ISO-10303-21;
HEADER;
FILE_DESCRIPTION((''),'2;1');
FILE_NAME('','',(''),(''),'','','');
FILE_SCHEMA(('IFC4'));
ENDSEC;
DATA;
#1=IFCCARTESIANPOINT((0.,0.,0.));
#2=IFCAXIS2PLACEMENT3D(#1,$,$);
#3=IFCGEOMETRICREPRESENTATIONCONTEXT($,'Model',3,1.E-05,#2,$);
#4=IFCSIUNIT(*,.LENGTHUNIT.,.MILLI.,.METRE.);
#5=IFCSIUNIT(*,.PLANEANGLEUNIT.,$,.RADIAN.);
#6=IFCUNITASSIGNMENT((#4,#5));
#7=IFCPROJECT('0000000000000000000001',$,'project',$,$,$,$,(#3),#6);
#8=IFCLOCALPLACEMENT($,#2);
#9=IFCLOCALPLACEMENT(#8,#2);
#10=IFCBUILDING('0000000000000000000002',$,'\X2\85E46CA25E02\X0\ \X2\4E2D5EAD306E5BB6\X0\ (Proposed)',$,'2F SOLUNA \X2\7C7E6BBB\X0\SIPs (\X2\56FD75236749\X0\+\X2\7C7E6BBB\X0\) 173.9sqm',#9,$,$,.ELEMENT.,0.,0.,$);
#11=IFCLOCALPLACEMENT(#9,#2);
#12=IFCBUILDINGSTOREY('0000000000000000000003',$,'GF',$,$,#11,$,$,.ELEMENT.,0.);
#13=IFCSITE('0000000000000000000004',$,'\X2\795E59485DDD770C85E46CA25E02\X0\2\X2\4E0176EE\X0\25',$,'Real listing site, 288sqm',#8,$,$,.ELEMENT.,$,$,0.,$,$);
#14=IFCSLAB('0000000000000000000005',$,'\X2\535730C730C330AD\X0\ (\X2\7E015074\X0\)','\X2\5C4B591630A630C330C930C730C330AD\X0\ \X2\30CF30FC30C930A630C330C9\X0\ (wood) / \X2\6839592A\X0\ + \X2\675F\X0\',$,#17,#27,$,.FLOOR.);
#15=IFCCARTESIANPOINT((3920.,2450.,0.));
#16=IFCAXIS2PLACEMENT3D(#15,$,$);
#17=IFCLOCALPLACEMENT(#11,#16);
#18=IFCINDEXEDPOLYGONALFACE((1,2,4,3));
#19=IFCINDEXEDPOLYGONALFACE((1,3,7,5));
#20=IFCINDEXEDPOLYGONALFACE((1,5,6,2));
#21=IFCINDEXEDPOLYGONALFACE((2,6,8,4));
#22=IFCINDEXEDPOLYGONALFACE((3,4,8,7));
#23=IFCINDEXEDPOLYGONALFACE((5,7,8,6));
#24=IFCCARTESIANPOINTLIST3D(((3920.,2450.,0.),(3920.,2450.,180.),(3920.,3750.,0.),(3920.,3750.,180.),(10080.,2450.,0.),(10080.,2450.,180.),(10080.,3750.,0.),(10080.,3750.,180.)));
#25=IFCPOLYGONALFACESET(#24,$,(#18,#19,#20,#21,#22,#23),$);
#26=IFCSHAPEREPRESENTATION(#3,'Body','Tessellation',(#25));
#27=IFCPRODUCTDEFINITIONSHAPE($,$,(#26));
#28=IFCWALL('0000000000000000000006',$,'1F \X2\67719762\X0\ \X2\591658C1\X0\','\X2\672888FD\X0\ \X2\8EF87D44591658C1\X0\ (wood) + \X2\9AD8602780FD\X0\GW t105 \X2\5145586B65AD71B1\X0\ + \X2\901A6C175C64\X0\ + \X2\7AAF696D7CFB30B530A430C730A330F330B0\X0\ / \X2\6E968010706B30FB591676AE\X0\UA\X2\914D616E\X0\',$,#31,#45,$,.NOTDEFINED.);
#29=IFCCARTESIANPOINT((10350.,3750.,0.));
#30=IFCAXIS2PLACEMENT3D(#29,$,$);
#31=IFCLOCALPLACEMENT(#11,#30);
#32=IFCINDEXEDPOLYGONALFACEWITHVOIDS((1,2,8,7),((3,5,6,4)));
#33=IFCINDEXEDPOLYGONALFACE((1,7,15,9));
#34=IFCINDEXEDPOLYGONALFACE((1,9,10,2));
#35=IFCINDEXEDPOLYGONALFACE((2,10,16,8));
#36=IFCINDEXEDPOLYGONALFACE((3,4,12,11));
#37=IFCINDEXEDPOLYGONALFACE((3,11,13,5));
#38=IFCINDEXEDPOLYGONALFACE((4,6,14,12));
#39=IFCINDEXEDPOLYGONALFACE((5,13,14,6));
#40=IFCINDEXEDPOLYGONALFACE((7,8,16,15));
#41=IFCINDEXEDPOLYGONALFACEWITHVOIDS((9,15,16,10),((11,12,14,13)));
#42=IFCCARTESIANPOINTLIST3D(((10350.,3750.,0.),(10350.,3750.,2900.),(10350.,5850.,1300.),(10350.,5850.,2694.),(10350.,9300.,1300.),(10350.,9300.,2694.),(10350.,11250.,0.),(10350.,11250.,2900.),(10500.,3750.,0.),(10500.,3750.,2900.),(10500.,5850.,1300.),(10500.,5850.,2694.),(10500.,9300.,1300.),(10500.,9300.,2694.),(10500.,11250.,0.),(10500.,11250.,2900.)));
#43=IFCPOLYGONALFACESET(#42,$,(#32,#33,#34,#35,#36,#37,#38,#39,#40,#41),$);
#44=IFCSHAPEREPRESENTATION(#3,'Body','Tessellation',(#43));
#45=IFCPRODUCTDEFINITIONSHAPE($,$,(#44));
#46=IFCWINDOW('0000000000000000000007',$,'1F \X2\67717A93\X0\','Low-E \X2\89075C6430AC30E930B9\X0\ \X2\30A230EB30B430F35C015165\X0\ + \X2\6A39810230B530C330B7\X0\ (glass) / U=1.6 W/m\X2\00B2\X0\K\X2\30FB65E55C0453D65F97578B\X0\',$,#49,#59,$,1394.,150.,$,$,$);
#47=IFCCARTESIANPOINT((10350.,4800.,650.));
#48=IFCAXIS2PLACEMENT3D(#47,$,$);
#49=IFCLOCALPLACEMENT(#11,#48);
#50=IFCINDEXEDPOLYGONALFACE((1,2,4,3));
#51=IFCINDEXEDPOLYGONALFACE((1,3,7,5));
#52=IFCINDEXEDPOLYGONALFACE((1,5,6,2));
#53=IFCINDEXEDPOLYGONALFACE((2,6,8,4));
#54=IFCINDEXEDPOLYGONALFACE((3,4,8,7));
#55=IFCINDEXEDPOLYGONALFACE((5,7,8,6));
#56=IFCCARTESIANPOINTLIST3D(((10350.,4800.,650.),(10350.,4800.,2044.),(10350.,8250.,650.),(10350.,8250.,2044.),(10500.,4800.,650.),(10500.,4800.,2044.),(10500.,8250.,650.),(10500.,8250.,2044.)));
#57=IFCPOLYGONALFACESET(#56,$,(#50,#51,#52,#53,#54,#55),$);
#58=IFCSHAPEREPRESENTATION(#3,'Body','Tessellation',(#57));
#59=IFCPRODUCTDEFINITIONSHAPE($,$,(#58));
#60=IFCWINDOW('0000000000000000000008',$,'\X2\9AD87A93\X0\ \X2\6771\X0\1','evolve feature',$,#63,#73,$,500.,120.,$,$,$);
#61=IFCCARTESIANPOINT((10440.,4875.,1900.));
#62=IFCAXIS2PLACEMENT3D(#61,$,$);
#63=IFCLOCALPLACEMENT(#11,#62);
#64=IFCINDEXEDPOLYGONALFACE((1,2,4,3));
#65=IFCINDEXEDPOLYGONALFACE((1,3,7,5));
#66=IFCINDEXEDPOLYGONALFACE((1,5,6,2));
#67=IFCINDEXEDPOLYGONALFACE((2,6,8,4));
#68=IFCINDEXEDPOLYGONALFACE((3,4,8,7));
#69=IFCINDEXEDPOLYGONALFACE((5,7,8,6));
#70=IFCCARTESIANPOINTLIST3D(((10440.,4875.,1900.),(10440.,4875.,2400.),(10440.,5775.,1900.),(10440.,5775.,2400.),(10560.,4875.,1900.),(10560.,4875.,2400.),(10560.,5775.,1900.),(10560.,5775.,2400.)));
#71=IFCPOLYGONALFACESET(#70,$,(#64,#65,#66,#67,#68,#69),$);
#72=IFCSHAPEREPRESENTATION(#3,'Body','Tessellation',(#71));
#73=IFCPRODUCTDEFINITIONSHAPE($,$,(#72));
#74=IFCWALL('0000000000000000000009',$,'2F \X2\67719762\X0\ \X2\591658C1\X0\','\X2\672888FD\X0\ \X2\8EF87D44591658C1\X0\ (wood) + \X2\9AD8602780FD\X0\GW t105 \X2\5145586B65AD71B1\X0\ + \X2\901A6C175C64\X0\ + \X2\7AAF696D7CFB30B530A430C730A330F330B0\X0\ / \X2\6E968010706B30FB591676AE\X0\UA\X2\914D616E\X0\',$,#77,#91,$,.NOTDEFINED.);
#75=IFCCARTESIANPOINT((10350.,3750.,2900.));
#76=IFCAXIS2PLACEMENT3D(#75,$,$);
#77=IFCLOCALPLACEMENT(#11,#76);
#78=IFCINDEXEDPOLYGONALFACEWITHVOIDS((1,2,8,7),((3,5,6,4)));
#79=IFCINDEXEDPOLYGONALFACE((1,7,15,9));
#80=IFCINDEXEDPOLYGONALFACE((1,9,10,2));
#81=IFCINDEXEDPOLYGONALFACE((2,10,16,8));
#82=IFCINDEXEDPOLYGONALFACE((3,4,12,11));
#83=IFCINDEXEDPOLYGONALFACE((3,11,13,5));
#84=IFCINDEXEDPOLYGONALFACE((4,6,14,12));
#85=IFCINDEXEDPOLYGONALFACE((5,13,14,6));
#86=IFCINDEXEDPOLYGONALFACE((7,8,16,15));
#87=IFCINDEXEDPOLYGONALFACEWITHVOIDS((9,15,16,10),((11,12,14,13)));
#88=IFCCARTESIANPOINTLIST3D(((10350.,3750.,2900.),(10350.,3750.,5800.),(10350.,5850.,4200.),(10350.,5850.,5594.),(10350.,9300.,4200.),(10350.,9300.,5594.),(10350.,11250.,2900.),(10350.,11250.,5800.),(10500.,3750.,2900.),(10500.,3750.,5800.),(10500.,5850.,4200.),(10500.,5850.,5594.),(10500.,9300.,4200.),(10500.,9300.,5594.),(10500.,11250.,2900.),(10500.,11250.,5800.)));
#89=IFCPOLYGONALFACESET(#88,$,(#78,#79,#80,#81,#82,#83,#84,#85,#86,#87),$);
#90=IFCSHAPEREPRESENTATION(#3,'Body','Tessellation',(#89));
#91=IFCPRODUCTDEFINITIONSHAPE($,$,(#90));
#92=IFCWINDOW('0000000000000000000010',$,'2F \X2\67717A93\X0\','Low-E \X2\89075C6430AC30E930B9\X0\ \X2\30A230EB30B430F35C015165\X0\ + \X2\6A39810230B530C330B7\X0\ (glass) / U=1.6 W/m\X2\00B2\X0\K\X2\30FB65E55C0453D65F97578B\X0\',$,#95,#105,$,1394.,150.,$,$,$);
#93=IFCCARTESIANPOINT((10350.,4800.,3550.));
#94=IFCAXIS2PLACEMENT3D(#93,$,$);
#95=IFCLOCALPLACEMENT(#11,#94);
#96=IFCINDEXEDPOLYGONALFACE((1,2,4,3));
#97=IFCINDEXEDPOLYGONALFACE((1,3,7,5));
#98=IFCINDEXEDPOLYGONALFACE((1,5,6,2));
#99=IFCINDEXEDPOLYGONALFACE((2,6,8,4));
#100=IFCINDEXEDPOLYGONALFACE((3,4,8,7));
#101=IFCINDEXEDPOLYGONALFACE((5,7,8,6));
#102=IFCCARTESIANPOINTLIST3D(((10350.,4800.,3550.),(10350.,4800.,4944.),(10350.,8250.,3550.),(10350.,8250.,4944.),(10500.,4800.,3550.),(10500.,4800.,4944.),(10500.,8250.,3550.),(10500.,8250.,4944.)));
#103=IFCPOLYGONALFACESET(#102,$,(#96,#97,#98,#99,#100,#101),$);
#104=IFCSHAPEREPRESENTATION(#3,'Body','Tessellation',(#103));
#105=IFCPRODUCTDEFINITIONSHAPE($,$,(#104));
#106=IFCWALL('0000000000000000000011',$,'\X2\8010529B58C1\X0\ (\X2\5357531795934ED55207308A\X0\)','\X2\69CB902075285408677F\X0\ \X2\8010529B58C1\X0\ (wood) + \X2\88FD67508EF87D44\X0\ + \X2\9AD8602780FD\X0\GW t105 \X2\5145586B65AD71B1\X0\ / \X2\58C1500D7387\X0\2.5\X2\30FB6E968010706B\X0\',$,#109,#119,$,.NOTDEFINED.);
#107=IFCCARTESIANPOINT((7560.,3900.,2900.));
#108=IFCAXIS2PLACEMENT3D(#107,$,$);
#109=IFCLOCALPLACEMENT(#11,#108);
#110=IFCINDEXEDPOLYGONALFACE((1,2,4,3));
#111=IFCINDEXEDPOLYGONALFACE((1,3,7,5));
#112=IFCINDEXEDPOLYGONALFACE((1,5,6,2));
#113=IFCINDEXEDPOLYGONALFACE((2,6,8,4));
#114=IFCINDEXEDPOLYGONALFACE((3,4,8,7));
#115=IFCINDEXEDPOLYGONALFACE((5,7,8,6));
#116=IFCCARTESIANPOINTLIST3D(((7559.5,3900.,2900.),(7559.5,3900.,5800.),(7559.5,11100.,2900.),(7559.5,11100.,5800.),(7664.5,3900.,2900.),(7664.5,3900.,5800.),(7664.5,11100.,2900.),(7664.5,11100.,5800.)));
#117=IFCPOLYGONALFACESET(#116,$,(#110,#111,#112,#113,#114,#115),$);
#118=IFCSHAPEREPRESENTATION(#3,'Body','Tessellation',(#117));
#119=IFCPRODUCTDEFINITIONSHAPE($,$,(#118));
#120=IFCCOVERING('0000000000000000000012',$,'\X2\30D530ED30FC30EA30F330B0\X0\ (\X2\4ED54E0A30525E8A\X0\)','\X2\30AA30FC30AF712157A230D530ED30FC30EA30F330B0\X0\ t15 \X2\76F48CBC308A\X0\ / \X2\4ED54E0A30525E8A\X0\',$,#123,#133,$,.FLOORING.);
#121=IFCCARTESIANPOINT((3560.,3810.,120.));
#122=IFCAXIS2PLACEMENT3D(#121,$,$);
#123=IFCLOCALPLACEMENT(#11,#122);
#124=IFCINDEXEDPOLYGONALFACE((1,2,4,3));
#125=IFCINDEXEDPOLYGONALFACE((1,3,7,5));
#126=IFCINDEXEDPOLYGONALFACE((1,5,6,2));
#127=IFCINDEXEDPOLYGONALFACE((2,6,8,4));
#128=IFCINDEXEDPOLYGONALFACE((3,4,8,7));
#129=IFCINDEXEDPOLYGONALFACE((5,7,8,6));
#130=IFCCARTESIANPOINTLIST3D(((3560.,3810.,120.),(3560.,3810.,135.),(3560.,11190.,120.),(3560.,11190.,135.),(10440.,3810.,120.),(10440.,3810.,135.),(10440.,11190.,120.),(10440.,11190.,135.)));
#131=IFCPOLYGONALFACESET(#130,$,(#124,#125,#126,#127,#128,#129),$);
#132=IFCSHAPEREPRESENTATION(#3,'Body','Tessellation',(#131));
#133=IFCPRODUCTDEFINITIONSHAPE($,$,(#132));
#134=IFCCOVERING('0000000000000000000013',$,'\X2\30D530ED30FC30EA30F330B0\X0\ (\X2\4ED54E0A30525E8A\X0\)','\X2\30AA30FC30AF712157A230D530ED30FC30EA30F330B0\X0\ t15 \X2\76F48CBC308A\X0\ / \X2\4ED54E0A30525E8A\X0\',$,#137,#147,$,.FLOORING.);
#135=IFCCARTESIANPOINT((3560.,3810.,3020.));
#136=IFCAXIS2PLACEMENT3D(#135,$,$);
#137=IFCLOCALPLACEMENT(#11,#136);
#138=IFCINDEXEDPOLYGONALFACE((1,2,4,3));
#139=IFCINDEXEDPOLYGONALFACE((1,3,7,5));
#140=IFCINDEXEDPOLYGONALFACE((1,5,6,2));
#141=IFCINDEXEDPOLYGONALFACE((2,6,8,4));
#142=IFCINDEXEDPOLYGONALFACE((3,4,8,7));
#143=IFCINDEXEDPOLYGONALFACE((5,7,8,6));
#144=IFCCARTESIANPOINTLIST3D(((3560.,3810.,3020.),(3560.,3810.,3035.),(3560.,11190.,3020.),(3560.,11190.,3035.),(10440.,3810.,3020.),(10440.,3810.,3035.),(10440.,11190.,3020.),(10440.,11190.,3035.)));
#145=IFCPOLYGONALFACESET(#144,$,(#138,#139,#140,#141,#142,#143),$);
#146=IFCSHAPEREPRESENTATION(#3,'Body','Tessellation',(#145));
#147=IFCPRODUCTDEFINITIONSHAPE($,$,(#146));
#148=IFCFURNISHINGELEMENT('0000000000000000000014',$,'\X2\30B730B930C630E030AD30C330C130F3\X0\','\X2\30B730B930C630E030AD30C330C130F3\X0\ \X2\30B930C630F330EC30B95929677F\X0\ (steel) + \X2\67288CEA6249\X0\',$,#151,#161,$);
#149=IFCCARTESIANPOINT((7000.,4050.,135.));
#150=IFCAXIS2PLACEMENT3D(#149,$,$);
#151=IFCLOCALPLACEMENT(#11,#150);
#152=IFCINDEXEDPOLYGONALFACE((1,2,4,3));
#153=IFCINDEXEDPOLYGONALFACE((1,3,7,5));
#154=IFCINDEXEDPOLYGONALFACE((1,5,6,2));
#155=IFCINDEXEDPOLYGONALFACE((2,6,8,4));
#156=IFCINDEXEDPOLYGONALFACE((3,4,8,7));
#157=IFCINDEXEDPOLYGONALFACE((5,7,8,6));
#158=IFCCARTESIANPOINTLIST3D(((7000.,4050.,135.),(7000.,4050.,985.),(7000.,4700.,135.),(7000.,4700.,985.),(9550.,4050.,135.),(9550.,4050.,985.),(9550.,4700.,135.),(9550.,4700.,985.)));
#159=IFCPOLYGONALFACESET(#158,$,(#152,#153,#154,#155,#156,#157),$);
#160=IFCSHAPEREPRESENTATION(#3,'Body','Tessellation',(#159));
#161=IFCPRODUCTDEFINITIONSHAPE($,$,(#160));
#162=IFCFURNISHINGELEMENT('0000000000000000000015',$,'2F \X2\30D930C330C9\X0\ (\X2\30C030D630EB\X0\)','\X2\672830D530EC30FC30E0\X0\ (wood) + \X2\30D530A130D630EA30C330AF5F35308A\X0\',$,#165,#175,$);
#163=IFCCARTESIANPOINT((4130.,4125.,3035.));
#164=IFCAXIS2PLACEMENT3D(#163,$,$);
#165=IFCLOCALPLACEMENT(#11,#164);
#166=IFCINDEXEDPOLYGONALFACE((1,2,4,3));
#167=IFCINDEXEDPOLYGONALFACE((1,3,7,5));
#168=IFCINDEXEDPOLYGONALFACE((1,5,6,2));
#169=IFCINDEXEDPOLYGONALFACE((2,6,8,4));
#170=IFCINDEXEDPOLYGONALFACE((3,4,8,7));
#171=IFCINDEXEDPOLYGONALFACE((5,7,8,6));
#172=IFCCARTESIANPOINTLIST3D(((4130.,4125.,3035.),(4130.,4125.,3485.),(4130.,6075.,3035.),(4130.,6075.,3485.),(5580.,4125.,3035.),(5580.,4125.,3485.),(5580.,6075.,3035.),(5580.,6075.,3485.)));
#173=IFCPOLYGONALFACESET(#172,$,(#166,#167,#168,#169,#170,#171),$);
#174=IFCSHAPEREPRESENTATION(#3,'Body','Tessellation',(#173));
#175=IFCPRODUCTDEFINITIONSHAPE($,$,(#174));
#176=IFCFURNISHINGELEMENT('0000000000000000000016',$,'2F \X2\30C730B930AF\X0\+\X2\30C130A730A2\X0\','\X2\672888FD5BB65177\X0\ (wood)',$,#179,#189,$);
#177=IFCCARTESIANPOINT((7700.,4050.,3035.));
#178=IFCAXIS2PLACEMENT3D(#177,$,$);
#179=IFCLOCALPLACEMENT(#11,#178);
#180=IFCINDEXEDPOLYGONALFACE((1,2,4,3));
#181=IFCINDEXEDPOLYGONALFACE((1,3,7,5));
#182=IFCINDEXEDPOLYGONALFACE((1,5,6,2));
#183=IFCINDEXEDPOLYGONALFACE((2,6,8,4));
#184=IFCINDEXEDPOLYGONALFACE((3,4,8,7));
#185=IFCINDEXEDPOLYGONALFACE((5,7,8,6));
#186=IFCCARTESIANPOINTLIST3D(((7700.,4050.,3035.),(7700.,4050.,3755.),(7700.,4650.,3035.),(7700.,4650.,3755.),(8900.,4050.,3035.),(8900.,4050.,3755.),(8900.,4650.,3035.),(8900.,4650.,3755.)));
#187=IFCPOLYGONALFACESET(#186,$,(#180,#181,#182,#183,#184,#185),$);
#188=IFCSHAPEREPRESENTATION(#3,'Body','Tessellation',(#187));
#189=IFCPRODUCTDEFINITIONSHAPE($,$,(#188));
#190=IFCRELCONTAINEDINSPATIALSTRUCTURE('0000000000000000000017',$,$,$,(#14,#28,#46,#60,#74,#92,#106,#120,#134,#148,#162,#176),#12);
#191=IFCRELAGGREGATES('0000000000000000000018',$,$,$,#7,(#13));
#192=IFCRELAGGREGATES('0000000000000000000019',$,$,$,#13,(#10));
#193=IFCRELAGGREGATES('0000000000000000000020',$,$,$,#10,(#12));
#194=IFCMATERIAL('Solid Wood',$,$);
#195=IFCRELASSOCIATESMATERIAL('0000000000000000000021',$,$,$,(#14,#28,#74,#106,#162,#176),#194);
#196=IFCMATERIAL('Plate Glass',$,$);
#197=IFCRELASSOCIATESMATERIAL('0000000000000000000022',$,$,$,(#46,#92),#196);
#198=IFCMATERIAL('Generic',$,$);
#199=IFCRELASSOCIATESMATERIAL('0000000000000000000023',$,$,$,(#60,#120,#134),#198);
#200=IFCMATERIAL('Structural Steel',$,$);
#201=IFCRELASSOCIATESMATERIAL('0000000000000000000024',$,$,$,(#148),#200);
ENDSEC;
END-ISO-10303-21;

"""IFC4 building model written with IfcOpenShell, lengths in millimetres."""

from ifc_helpers import new_model, si_unit, frame, frame_2d, origin, place, context, project, spatial, rectangle, extrude, material, element, fill, save


model = new_model("IFC4")

# Units and contexts
model_context = context("Model", 3, precision=1e-05, world=origin())
ifc_project = project(units=[si_unit("LENGTHUNIT", "METRE", prefix="MILLI"), si_unit("PLANEANGLEUNIT", "RADIAN")], contexts=[model_context])

# Site, building, storey
site_placement = place(None, origin())
site = spatial("IfcSite", under=ifc_project, at=site_placement, Name="神奈川県藤沢市2丁目25", ObjectType="Real listing site, 288sqm", CompositionType="ELEMENT", RefElevation=0.0)
building_placement = place(site_placement, origin())
building = spatial("IfcBuilding", under=site, at=building_placement, Name="藤沢市 中庭の家 (Proposed)", ObjectType="2F SOLUNA 籾殻SIPs (国産杉+籾殻) 173.9sqm", CompositionType="ELEMENT", ElevationOfRefHeight=0.0, ElevationOfTerrain=0.0)
storey_placement = place(building_placement, origin())
storey = spatial("IfcBuildingStorey", under=building, at=storey_placement, Name="GF", CompositionType="ELEMENT", Elevation=0.0)

# Slab
ifc_material_1 = material(Name="Solid Wood")
slab_placement = place(storey_placement, frame((3920.0, 2450.0, 0.0)))
element("IfcSlab", 1, at=slab_placement, inside=storey, material=ifc_material_1, Name="南デッキ (縁側)", Description="屋外ウッドデッキ ハードウッド (wood) / 根太 + 束", PredefinedType="FLOOR", context=model_context, shape_type="SweptSolid", body=[
    extrude(rectangle(XDim=6160.0, YDim=1300.0, at=frame_2d((3080.0, 650.0))), frame((3920.0, 2450.0, 0.0)), (0.0, 0.0, 1.0), 180.0),
])

# Wall, openings, windows
wall_1_placement = place(storey_placement, frame((10350.0, 3750.0, 0.0)))
wall_1 = element("IfcWall", 2, at=wall_1_placement, inside=storey, material=ifc_material_1, Name="1F 東面 外壁", Description="木製 軸組外壁 (wood) + 高性能GW t105 充填断熱 + 通気層 + 窯業系サイディング / 準耐火・外皮UA配慮", PredefinedType="NOTDEFINED", context=model_context, shape_type="SweptSolid", body=[
    extrude(rectangle(XDim=150.0, YDim=7500.0, at=frame_2d((75.0, 3750.0))), frame((10350.0, 3750.0, 0.0)), (0.0, 0.0, 1.0), 2900.0),
])
opening_1_placement = place(storey_placement, frame((10350.0, 4800.0, 650.0)))
opening_1 = element("IfcOpeningElement", 3, at=opening_1_placement, cuts=wall_1, PredefinedType="NOTDEFINED", context=model_context, shape_type="SweptSolid", body=[
    extrude(rectangle(XDim=150.0, YDim=3450.0, at=frame_2d((75.0, 1725.0))), frame((10350.0, 4800.0, 650.0)), (0.0, 0.0, 1.0), 1394.0),
])
opening_2_placement = place(storey_placement, frame((10440.0, 4875.0, 1900.0)))
opening_2 = element("IfcOpeningElement", 4, at=opening_2_placement, cuts=wall_1, PredefinedType="NOTDEFINED", context=model_context, shape_type="SweptSolid", body=[
    extrude(rectangle(XDim=120.0, YDim=900.0, at=frame_2d((60.0, 450.0))), frame((10440.0, 4875.0, 1900.0)), (0.0, 0.0, 1.0), 500.0),
])
ifc_material_2 = material(Name="Plate Glass")
window_1_placement = place(storey_placement, frame((10350.0, 4800.0, 650.0)))
window_1 = element("IfcWindow", 5, at=window_1_placement, inside=storey, material=ifc_material_2, Name="1F 東窓", Description="Low-E 複層ガラス アルゴン封入 + 樹脂サッシ (glass) / U=1.6 W/m²K・日射取得型", OverallHeight=1394.0, OverallWidth=150.0, context=model_context, shape_type="SweptSolid", body=[
    extrude(rectangle(XDim=150.0, YDim=3450.0, at=frame_2d((75.0, 1725.0))), frame((10350.0, 4800.0, 650.0)), (0.0, 0.0, 1.0), 1394.0),
])
fill(opening_1, window_1)
ifc_material_3 = material(Name="Generic")
window_2_placement = place(storey_placement, frame((10440.0, 4875.0, 1900.0)))
window_2 = element("IfcWindow", 6, at=window_2_placement, inside=storey, material=ifc_material_3, Name="高窓 東1", Description="evolve feature", OverallHeight=500.0, OverallWidth=120.0, context=model_context, shape_type="SweptSolid", body=[
    extrude(rectangle(XDim=120.0, YDim=900.0, at=frame_2d((60.0, 450.0))), frame((10440.0, 4875.0, 1900.0)), (0.0, 0.0, 1.0), 500.0),
])
fill(opening_2, window_2)

# Wall, opening, window
wall_2_placement = place(storey_placement, frame((10350.0, 3750.0, 2900.0)))
wall_2 = element("IfcWall", 7, at=wall_2_placement, inside=storey, material=ifc_material_1, Name="2F 東面 外壁", Description="木製 軸組外壁 (wood) + 高性能GW t105 充填断熱 + 通気層 + 窯業系サイディング / 準耐火・外皮UA配慮", PredefinedType="NOTDEFINED", context=model_context, shape_type="SweptSolid", body=[
    extrude(rectangle(XDim=150.0, YDim=7500.0, at=frame_2d((75.0, 3750.0))), frame((10350.0, 3750.0, 2900.0)), (0.0, 0.0, 1.0), 2900.0),
])
opening_3_placement = place(storey_placement, frame((10350.0, 4800.0, 3550.0)))
opening_3 = element("IfcOpeningElement", 8, at=opening_3_placement, cuts=wall_2, PredefinedType="NOTDEFINED", context=model_context, shape_type="SweptSolid", body=[
    extrude(rectangle(XDim=150.0, YDim=3450.0, at=frame_2d((75.0, 1725.0))), frame((10350.0, 4800.0, 3550.0)), (0.0, 0.0, 1.0), 1394.0),
])
window_3_placement = place(storey_placement, frame((10350.0, 4800.0, 3550.0)))
window_3 = element("IfcWindow", 9, at=window_3_placement, inside=storey, material=ifc_material_2, Name="2F 東窓", Description="Low-E 複層ガラス アルゴン封入 + 樹脂サッシ (glass) / U=1.6 W/m²K・日射取得型", OverallHeight=1394.0, OverallWidth=150.0, context=model_context, shape_type="SweptSolid", body=[
    extrude(rectangle(XDim=150.0, YDim=3450.0, at=frame_2d((75.0, 1725.0))), frame((10350.0, 4800.0, 3550.0)), (0.0, 0.0, 1.0), 1394.0),
])
fill(opening_3, window_3)

# Wall
wall_3_placement = place(storey_placement, frame((7560.0, 3900.0, 2900.0)))
element("IfcWall", 10, at=wall_3_placement, inside=storey, material=ifc_material_1, Name="耐力壁 (南北間仕切り)", Description="構造用合板 耐力壁 (wood) + 製材軸組 + 高性能GW t105 充填断熱 / 壁倍率2.5・準耐火", PredefinedType="NOTDEFINED", context=model_context, shape_type="SweptSolid", body=[
    extrude(rectangle(XDim=105.0, YDim=7200.0, at=frame_2d((52.0, 3600.0))), frame((7560.0, 3900.0, 2900.0)), (0.0, 0.0, 1.0), 2900.0),
])

# Coverings
covering_1_placement = place(storey_placement, frame((3560.0, 3810.0, 120.0)))
element("IfcCovering", 11, at=covering_1_placement, inside=storey, material=ifc_material_3, Name="フローリング (仕上げ床)", Description="オーク無垢フローリング t15 直貼り / 仕上げ床", PredefinedType="FLOORING", context=model_context, shape_type="SweptSolid", body=[
    extrude(rectangle(XDim=6880.0, YDim=7380.0, at=frame_2d((3440.0, 3690.0))), frame((3560.0, 3810.0, 120.0)), (0.0, 0.0, 1.0), 15.0),
])
covering_2_placement = place(storey_placement, frame((3560.0, 3810.0, 3020.0)))
element("IfcCovering", 12, at=covering_2_placement, inside=storey, material=ifc_material_3, Name="フローリング (仕上げ床)", Description="オーク無垢フローリング t15 直貼り / 仕上げ床", PredefinedType="FLOORING", context=model_context, shape_type="SweptSolid", body=[
    extrude(rectangle(XDim=6880.0, YDim=7380.0, at=frame_2d((3440.0, 3690.0))), frame((3560.0, 3810.0, 3020.0)), (0.0, 0.0, 1.0), 15.0),
])

# Furnishing elements
ifc_material_4 = material(Name="Structural Steel")
furnishing_1_placement = place(storey_placement, frame((7000.0, 4050.0, 135.0)))
element("IfcFurnishingElement", 13, at=furnishing_1_placement, inside=storey, material=ifc_material_4, Name="システムキッチン", Description="システムキッチン ステンレス天板 (steel) + 木質扉", context=model_context, shape_type="SweptSolid", body=[
    extrude(rectangle(XDim=2550.0, YDim=650.0, at=frame_2d((1275.0, 325.0))), frame((7000.0, 4050.0, 135.0)), (0.0, 0.0, 1.0), 850.0),
])
furnishing_2_placement = place(storey_placement, frame((4130.0, 4125.0, 3035.0)))
element("IfcFurnishingElement", 14, at=furnishing_2_placement, inside=storey, material=ifc_material_1, Name="2F ベッド (ダブル)", Description="木フレーム (wood) + ファブリック張り", context=model_context, shape_type="SweptSolid", body=[
    extrude(rectangle(XDim=1450.0, YDim=1950.0, at=frame_2d((725.0, 975.0))), frame((4130.0, 4125.0, 3035.0)), (0.0, 0.0, 1.0), 450.0),
])
furnishing_3_placement = place(storey_placement, frame((7700.0, 4050.0, 3035.0)))
element("IfcFurnishingElement", 15, at=furnishing_3_placement, inside=storey, material=ifc_material_1, Name="2F デスク+チェア", Description="木製家具 (wood)", context=model_context, shape_type="SweptSolid", body=[
    extrude(rectangle(XDim=1200.0, YDim=600.0, at=frame_2d((600.0, 300.0))), frame((7700.0, 4050.0, 3035.0)), (0.0, 0.0, 1.0), 720.0),
])

save(model, "model.ifc")
